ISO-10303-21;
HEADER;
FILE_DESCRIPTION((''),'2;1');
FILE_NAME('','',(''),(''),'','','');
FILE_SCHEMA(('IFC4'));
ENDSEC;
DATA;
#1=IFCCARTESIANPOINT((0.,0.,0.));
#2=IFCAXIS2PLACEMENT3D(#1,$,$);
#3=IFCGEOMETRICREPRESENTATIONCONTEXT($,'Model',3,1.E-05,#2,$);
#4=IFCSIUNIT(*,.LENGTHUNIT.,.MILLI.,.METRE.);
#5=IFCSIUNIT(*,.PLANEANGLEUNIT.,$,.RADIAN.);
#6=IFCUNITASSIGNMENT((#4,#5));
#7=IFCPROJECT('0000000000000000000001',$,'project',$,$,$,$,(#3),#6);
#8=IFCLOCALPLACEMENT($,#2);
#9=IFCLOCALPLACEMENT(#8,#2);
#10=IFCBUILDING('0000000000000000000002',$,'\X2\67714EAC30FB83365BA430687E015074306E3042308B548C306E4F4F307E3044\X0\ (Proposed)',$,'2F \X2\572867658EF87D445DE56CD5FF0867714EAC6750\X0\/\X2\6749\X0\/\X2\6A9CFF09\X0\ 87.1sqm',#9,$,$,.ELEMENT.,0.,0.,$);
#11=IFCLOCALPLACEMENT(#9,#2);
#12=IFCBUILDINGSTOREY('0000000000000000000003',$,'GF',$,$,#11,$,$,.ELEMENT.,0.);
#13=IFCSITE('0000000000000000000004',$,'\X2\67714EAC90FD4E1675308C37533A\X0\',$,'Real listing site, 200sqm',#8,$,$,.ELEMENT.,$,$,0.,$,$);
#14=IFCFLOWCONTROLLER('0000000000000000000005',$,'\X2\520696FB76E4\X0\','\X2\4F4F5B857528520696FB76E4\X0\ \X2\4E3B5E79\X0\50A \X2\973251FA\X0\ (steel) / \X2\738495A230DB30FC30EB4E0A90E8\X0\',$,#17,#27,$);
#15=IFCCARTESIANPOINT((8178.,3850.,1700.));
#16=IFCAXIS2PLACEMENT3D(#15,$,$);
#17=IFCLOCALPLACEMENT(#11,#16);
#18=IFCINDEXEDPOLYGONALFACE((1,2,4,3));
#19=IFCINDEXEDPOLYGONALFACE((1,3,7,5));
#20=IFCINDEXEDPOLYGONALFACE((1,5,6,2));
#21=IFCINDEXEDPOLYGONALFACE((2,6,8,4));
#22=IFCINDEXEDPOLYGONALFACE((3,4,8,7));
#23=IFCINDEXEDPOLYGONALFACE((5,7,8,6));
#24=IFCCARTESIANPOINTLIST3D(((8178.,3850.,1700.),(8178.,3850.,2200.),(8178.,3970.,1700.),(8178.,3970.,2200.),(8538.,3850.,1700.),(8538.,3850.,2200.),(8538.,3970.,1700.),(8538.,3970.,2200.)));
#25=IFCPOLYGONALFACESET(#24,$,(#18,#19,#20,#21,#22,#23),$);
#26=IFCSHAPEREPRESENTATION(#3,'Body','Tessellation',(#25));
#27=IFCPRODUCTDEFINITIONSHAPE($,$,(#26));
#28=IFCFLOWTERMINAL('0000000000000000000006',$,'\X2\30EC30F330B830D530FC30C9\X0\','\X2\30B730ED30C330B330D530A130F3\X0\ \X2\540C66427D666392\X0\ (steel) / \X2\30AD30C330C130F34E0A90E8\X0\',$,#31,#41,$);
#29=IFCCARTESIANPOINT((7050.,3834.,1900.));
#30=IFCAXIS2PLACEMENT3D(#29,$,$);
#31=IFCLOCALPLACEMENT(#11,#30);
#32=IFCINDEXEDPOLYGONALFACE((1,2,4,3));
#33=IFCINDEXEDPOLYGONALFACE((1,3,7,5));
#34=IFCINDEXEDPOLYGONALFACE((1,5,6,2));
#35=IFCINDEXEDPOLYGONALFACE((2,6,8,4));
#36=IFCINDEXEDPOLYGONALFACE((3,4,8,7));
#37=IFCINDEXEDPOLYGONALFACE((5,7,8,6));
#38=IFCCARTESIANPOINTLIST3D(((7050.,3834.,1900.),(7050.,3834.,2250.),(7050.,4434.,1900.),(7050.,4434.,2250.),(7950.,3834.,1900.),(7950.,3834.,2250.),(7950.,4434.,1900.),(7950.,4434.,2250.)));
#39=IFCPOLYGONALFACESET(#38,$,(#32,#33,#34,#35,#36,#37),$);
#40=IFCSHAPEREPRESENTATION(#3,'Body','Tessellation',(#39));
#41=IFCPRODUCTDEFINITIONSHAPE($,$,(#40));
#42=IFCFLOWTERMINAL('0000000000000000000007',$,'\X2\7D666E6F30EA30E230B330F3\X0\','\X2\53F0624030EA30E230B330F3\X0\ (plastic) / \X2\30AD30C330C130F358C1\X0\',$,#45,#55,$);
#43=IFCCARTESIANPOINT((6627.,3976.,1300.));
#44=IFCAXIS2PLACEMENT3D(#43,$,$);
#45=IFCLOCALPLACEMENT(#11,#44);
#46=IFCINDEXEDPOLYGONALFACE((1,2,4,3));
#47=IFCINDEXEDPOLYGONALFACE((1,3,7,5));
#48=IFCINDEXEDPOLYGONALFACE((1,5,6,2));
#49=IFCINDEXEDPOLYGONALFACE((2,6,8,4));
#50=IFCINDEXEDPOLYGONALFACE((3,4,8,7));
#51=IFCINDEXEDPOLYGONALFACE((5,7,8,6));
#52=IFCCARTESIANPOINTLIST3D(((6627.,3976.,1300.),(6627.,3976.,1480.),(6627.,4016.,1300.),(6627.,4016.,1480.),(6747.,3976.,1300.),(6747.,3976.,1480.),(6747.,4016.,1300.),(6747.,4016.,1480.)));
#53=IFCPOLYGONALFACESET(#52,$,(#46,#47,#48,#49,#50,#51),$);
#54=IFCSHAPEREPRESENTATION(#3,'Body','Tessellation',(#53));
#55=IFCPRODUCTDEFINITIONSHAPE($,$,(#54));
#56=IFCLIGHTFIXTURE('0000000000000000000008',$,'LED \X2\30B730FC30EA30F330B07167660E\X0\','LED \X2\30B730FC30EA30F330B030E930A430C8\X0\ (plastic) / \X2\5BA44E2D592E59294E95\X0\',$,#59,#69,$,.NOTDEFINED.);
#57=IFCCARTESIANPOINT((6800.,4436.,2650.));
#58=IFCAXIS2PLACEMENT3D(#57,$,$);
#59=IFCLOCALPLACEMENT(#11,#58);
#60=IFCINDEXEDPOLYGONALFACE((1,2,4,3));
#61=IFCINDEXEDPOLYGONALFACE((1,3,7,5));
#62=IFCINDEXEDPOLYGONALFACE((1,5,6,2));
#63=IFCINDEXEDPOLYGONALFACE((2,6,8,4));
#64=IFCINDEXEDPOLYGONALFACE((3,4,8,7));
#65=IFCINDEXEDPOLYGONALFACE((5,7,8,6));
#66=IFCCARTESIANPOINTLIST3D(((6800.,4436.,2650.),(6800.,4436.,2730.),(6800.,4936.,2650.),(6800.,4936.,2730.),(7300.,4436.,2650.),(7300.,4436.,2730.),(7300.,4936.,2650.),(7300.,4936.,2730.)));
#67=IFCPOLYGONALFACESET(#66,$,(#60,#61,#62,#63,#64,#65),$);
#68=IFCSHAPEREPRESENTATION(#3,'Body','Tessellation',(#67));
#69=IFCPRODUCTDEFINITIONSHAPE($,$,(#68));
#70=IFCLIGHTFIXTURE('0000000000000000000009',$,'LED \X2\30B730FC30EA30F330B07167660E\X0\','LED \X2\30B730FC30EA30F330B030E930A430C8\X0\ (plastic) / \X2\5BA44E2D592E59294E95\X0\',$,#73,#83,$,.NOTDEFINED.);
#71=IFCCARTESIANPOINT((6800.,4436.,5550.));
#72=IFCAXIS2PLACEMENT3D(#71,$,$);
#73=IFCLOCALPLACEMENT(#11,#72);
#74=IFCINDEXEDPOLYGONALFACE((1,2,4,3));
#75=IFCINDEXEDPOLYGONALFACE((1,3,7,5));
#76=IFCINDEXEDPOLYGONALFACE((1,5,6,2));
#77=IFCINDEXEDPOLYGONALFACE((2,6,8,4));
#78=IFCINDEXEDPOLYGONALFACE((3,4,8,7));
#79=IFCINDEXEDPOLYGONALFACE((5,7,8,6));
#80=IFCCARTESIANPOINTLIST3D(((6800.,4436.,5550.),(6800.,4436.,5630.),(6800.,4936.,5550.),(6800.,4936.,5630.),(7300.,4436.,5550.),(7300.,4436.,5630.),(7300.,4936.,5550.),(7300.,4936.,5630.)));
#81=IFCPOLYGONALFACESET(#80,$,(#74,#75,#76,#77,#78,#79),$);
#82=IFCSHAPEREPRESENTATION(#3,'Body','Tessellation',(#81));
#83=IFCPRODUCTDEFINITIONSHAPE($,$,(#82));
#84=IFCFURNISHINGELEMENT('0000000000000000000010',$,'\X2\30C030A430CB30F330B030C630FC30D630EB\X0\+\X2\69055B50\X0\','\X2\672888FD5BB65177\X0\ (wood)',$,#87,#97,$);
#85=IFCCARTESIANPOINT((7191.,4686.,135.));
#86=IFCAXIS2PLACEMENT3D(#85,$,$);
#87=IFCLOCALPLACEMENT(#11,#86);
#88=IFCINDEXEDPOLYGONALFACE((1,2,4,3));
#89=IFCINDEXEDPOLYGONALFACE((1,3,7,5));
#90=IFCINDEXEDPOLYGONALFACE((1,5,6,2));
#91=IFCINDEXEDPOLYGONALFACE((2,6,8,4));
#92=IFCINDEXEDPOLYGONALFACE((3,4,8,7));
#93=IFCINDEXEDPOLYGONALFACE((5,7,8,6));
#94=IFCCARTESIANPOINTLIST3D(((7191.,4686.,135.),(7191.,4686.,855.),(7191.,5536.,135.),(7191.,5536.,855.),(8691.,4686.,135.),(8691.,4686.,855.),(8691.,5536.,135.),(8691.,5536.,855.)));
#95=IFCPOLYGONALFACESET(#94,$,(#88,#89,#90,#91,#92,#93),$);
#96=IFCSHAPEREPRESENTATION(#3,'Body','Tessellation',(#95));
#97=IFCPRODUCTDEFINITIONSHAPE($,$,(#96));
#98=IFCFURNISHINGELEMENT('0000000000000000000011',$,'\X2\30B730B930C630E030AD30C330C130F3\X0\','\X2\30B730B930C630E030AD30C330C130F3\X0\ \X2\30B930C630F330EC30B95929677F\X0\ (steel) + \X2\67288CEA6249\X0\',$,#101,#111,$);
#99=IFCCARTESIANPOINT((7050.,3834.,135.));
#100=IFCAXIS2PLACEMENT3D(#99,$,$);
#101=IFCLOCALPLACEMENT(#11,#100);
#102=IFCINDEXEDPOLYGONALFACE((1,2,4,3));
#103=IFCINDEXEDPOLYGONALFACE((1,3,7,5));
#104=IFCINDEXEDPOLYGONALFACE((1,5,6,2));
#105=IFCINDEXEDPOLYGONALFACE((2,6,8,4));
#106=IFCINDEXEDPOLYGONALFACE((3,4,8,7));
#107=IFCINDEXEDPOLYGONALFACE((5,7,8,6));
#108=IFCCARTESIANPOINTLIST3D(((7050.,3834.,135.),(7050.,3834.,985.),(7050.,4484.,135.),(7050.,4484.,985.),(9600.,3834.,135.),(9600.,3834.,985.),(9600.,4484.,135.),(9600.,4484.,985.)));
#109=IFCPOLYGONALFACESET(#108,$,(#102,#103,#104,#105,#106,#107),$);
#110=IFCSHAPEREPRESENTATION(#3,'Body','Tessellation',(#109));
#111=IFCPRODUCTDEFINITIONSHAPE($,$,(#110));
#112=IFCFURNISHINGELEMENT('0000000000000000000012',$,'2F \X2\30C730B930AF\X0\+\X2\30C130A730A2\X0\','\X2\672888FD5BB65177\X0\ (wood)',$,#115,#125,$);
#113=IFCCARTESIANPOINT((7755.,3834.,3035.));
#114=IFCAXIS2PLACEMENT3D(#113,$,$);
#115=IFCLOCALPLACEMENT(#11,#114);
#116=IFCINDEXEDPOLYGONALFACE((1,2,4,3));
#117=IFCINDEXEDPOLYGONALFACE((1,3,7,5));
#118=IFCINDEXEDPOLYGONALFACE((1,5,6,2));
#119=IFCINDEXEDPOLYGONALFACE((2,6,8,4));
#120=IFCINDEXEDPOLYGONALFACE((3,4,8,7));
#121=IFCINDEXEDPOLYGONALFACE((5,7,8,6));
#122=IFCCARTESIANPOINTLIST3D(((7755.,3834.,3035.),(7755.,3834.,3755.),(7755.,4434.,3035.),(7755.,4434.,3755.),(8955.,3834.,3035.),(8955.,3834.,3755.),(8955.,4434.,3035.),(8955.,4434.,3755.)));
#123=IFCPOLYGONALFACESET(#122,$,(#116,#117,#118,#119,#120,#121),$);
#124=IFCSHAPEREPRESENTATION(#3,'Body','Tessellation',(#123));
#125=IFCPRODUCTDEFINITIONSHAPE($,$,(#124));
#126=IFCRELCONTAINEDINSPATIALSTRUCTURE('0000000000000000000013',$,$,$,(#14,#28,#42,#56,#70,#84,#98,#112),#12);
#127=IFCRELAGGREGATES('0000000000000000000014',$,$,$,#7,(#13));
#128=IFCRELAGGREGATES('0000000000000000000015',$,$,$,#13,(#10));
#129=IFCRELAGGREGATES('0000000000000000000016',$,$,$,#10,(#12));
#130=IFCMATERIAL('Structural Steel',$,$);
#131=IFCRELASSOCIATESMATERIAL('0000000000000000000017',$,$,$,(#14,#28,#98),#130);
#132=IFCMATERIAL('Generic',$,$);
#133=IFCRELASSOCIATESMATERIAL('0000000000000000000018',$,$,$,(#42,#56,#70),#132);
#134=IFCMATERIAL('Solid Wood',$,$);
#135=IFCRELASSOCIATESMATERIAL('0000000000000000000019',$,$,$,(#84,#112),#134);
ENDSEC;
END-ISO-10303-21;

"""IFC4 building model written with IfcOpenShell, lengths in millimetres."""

from ifc_helpers import new_model, si_unit, frame, frame_2d, origin, place, context, project, spatial, rectangle, extrude, material, element, save


model = new_model("IFC4")

# Units and contexts
model_context = context("Model", 3, precision=1e-05, world=origin())
ifc_project = project(units=[si_unit("LENGTHUNIT", "METRE", prefix="MILLI"), si_unit("PLANEANGLEUNIT", "RADIAN")], contexts=[model_context])

# Site, building, storey
site_placement = place(None, origin())
site = spatial("IfcSite", under=ifc_project, at=site_placement, Name="東京都世田谷区", ObjectType="Real listing site, 200sqm", CompositionType="ELEMENT", RefElevation=0.0)
building_placement = place(site_placement, origin())
building = spatial("IfcBuilding", under=site, at=building_placement, Name="東京・茶室と縁側のある和の住まい (Proposed)", ObjectType="2F 在来軸組工法（東京材/杉/檜） 87.1sqm", CompositionType="ELEMENT", ElevationOfRefHeight=0.0, ElevationOfTerrain=0.0)
storey_placement = place(building_placement, origin())
storey = spatial("IfcBuildingStorey", under=building, at=storey_placement, Name="GF", CompositionType="ELEMENT", Elevation=0.0)

# Shared definitions
ifc_material_1 = material(Name="Solid Wood")

# Shared definitions
ifc_material_2 = material(Name="Structural Steel")

# Flow controller
flow_controller_placement = place(storey_placement, frame((8178.0, 3850.0, 1700.0)))
element("IfcFlowController", 1, at=flow_controller_placement, inside=storey, material=ifc_material_2, Name="分電盤", Description="住宅用分電盤 主幹50A 露出 (steel) / 玄関ホール上部", context=model_context, shape_type="SweptSolid", body=[
    extrude(rectangle(XDim=360.0, YDim=120.0, at=frame_2d((180.0, 60.0))), frame((8178.0, 3850.0, 1700.0)), (0.0, 0.0, 1.0), 500.0),
])

# Flow terminals
flow_terminal_1_placement = place(storey_placement, frame((7050.0, 3834.0, 1900.0)))
element("IfcFlowTerminal", 2, at=flow_terminal_1_placement, inside=storey, material=ifc_material_2, Name="レンジフード", Description="シロッコファン 同時給排 (steel) / キッチン上部", context=model_context, shape_type="SweptSolid", body=[
    extrude(rectangle(XDim=900.0, YDim=600.0, at=frame_2d((450.0, 300.0))), frame((7050.0, 3834.0, 1900.0)), (0.0, 0.0, 1.0), 350.0),
])
ifc_material_3 = material(Name="Generic")
flow_terminal_2_placement = place(storey_placement, frame((6627.0, 3976.0, 1300.0)))
element("IfcFlowTerminal", 3, at=flow_terminal_2_placement, inside=storey, material=ifc_material_3, Name="給湯リモコン", Description="台所リモコン (plastic) / キッチン壁", context=model_context, shape_type="SweptSolid", body=[
    extrude(rectangle(XDim=120.0, YDim=40.0, at=frame_2d((60.0, 20.0))), frame((6627.0, 3976.0, 1300.0)), (0.0, 0.0, 1.0), 180.0),
])

# Light fixtures
light_fixture_1_placement = place(storey_placement, frame((6800.0, 4436.0, 2650.0)))
element("IfcLightFixture", 4, at=light_fixture_1_placement, inside=storey, material=ifc_material_3, Name="LED シーリング照明", Description="LED シーリングライト (plastic) / 室中央天井", PredefinedType="NOTDEFINED", context=model_context, shape_type="SweptSolid", body=[
    extrude(rectangle(XDim=500.0, YDim=500.0, at=frame_2d((250.0, 250.0))), frame((6800.0, 4436.0, 2650.0)), (0.0, 0.0, 1.0), 80.0),
])
light_fixture_2_placement = place(storey_placement, frame((6800.0, 4436.0, 5550.0)))
element("IfcLightFixture", 5, at=light_fixture_2_placement, inside=storey, material=ifc_material_3, Name="LED シーリング照明", Description="LED シーリングライト (plastic) / 室中央天井", PredefinedType="NOTDEFINED", context=model_context, shape_type="SweptSolid", body=[
    extrude(rectangle(XDim=500.0, YDim=500.0, at=frame_2d((250.0, 250.0))), frame((6800.0, 4436.0, 5550.0)), (0.0, 0.0, 1.0), 80.0),
])

# Furnishing elements
furnishing_1_placement = place(storey_placement, frame((7191.0, 4686.0, 135.0)))
element("IfcFurnishingElement", 6, at=furnishing_1_placement, inside=storey, material=ifc_material_1, Name="ダイニングテーブル+椅子", Description="木製家具 (wood)", context=model_context, shape_type="SweptSolid", body=[
    extrude(rectangle(XDim=1500.0, YDim=850.0, at=frame_2d((750.0, 425.0))), frame((7191.0, 4686.0, 135.0)), (0.0, 0.0, 1.0), 720.0),
])
furnishing_2_placement = place(storey_placement, frame((7050.0, 3834.0, 135.0)))
element("IfcFurnishingElement", 7, at=furnishing_2_placement, inside=storey, material=ifc_material_2, Name="システムキッチン", Description="システムキッチン ステンレス天板 (steel) + 木質扉", context=model_context, shape_type="SweptSolid", body=[
    extrude(rectangle(XDim=2550.0, YDim=650.0, at=frame_2d((1275.0, 325.0))), frame((7050.0, 3834.0, 135.0)), (0.0, 0.0, 1.0), 850.0),
])
furnishing_3_placement = place(storey_placement, frame((7755.0, 3834.0, 3035.0)))
element("IfcFurnishingElement", 8, at=furnishing_3_placement, inside=storey, material=ifc_material_1, Name="2F デスク+チェア", Description="木製家具 (wood)", context=model_context, shape_type="SweptSolid", body=[
    extrude(rectangle(XDim=1200.0, YDim=600.0, at=frame_2d((600.0, 300.0))), frame((7755.0, 3834.0, 3035.0)), (0.0, 0.0, 1.0), 720.0),
])

save(model, "model.ifc")
